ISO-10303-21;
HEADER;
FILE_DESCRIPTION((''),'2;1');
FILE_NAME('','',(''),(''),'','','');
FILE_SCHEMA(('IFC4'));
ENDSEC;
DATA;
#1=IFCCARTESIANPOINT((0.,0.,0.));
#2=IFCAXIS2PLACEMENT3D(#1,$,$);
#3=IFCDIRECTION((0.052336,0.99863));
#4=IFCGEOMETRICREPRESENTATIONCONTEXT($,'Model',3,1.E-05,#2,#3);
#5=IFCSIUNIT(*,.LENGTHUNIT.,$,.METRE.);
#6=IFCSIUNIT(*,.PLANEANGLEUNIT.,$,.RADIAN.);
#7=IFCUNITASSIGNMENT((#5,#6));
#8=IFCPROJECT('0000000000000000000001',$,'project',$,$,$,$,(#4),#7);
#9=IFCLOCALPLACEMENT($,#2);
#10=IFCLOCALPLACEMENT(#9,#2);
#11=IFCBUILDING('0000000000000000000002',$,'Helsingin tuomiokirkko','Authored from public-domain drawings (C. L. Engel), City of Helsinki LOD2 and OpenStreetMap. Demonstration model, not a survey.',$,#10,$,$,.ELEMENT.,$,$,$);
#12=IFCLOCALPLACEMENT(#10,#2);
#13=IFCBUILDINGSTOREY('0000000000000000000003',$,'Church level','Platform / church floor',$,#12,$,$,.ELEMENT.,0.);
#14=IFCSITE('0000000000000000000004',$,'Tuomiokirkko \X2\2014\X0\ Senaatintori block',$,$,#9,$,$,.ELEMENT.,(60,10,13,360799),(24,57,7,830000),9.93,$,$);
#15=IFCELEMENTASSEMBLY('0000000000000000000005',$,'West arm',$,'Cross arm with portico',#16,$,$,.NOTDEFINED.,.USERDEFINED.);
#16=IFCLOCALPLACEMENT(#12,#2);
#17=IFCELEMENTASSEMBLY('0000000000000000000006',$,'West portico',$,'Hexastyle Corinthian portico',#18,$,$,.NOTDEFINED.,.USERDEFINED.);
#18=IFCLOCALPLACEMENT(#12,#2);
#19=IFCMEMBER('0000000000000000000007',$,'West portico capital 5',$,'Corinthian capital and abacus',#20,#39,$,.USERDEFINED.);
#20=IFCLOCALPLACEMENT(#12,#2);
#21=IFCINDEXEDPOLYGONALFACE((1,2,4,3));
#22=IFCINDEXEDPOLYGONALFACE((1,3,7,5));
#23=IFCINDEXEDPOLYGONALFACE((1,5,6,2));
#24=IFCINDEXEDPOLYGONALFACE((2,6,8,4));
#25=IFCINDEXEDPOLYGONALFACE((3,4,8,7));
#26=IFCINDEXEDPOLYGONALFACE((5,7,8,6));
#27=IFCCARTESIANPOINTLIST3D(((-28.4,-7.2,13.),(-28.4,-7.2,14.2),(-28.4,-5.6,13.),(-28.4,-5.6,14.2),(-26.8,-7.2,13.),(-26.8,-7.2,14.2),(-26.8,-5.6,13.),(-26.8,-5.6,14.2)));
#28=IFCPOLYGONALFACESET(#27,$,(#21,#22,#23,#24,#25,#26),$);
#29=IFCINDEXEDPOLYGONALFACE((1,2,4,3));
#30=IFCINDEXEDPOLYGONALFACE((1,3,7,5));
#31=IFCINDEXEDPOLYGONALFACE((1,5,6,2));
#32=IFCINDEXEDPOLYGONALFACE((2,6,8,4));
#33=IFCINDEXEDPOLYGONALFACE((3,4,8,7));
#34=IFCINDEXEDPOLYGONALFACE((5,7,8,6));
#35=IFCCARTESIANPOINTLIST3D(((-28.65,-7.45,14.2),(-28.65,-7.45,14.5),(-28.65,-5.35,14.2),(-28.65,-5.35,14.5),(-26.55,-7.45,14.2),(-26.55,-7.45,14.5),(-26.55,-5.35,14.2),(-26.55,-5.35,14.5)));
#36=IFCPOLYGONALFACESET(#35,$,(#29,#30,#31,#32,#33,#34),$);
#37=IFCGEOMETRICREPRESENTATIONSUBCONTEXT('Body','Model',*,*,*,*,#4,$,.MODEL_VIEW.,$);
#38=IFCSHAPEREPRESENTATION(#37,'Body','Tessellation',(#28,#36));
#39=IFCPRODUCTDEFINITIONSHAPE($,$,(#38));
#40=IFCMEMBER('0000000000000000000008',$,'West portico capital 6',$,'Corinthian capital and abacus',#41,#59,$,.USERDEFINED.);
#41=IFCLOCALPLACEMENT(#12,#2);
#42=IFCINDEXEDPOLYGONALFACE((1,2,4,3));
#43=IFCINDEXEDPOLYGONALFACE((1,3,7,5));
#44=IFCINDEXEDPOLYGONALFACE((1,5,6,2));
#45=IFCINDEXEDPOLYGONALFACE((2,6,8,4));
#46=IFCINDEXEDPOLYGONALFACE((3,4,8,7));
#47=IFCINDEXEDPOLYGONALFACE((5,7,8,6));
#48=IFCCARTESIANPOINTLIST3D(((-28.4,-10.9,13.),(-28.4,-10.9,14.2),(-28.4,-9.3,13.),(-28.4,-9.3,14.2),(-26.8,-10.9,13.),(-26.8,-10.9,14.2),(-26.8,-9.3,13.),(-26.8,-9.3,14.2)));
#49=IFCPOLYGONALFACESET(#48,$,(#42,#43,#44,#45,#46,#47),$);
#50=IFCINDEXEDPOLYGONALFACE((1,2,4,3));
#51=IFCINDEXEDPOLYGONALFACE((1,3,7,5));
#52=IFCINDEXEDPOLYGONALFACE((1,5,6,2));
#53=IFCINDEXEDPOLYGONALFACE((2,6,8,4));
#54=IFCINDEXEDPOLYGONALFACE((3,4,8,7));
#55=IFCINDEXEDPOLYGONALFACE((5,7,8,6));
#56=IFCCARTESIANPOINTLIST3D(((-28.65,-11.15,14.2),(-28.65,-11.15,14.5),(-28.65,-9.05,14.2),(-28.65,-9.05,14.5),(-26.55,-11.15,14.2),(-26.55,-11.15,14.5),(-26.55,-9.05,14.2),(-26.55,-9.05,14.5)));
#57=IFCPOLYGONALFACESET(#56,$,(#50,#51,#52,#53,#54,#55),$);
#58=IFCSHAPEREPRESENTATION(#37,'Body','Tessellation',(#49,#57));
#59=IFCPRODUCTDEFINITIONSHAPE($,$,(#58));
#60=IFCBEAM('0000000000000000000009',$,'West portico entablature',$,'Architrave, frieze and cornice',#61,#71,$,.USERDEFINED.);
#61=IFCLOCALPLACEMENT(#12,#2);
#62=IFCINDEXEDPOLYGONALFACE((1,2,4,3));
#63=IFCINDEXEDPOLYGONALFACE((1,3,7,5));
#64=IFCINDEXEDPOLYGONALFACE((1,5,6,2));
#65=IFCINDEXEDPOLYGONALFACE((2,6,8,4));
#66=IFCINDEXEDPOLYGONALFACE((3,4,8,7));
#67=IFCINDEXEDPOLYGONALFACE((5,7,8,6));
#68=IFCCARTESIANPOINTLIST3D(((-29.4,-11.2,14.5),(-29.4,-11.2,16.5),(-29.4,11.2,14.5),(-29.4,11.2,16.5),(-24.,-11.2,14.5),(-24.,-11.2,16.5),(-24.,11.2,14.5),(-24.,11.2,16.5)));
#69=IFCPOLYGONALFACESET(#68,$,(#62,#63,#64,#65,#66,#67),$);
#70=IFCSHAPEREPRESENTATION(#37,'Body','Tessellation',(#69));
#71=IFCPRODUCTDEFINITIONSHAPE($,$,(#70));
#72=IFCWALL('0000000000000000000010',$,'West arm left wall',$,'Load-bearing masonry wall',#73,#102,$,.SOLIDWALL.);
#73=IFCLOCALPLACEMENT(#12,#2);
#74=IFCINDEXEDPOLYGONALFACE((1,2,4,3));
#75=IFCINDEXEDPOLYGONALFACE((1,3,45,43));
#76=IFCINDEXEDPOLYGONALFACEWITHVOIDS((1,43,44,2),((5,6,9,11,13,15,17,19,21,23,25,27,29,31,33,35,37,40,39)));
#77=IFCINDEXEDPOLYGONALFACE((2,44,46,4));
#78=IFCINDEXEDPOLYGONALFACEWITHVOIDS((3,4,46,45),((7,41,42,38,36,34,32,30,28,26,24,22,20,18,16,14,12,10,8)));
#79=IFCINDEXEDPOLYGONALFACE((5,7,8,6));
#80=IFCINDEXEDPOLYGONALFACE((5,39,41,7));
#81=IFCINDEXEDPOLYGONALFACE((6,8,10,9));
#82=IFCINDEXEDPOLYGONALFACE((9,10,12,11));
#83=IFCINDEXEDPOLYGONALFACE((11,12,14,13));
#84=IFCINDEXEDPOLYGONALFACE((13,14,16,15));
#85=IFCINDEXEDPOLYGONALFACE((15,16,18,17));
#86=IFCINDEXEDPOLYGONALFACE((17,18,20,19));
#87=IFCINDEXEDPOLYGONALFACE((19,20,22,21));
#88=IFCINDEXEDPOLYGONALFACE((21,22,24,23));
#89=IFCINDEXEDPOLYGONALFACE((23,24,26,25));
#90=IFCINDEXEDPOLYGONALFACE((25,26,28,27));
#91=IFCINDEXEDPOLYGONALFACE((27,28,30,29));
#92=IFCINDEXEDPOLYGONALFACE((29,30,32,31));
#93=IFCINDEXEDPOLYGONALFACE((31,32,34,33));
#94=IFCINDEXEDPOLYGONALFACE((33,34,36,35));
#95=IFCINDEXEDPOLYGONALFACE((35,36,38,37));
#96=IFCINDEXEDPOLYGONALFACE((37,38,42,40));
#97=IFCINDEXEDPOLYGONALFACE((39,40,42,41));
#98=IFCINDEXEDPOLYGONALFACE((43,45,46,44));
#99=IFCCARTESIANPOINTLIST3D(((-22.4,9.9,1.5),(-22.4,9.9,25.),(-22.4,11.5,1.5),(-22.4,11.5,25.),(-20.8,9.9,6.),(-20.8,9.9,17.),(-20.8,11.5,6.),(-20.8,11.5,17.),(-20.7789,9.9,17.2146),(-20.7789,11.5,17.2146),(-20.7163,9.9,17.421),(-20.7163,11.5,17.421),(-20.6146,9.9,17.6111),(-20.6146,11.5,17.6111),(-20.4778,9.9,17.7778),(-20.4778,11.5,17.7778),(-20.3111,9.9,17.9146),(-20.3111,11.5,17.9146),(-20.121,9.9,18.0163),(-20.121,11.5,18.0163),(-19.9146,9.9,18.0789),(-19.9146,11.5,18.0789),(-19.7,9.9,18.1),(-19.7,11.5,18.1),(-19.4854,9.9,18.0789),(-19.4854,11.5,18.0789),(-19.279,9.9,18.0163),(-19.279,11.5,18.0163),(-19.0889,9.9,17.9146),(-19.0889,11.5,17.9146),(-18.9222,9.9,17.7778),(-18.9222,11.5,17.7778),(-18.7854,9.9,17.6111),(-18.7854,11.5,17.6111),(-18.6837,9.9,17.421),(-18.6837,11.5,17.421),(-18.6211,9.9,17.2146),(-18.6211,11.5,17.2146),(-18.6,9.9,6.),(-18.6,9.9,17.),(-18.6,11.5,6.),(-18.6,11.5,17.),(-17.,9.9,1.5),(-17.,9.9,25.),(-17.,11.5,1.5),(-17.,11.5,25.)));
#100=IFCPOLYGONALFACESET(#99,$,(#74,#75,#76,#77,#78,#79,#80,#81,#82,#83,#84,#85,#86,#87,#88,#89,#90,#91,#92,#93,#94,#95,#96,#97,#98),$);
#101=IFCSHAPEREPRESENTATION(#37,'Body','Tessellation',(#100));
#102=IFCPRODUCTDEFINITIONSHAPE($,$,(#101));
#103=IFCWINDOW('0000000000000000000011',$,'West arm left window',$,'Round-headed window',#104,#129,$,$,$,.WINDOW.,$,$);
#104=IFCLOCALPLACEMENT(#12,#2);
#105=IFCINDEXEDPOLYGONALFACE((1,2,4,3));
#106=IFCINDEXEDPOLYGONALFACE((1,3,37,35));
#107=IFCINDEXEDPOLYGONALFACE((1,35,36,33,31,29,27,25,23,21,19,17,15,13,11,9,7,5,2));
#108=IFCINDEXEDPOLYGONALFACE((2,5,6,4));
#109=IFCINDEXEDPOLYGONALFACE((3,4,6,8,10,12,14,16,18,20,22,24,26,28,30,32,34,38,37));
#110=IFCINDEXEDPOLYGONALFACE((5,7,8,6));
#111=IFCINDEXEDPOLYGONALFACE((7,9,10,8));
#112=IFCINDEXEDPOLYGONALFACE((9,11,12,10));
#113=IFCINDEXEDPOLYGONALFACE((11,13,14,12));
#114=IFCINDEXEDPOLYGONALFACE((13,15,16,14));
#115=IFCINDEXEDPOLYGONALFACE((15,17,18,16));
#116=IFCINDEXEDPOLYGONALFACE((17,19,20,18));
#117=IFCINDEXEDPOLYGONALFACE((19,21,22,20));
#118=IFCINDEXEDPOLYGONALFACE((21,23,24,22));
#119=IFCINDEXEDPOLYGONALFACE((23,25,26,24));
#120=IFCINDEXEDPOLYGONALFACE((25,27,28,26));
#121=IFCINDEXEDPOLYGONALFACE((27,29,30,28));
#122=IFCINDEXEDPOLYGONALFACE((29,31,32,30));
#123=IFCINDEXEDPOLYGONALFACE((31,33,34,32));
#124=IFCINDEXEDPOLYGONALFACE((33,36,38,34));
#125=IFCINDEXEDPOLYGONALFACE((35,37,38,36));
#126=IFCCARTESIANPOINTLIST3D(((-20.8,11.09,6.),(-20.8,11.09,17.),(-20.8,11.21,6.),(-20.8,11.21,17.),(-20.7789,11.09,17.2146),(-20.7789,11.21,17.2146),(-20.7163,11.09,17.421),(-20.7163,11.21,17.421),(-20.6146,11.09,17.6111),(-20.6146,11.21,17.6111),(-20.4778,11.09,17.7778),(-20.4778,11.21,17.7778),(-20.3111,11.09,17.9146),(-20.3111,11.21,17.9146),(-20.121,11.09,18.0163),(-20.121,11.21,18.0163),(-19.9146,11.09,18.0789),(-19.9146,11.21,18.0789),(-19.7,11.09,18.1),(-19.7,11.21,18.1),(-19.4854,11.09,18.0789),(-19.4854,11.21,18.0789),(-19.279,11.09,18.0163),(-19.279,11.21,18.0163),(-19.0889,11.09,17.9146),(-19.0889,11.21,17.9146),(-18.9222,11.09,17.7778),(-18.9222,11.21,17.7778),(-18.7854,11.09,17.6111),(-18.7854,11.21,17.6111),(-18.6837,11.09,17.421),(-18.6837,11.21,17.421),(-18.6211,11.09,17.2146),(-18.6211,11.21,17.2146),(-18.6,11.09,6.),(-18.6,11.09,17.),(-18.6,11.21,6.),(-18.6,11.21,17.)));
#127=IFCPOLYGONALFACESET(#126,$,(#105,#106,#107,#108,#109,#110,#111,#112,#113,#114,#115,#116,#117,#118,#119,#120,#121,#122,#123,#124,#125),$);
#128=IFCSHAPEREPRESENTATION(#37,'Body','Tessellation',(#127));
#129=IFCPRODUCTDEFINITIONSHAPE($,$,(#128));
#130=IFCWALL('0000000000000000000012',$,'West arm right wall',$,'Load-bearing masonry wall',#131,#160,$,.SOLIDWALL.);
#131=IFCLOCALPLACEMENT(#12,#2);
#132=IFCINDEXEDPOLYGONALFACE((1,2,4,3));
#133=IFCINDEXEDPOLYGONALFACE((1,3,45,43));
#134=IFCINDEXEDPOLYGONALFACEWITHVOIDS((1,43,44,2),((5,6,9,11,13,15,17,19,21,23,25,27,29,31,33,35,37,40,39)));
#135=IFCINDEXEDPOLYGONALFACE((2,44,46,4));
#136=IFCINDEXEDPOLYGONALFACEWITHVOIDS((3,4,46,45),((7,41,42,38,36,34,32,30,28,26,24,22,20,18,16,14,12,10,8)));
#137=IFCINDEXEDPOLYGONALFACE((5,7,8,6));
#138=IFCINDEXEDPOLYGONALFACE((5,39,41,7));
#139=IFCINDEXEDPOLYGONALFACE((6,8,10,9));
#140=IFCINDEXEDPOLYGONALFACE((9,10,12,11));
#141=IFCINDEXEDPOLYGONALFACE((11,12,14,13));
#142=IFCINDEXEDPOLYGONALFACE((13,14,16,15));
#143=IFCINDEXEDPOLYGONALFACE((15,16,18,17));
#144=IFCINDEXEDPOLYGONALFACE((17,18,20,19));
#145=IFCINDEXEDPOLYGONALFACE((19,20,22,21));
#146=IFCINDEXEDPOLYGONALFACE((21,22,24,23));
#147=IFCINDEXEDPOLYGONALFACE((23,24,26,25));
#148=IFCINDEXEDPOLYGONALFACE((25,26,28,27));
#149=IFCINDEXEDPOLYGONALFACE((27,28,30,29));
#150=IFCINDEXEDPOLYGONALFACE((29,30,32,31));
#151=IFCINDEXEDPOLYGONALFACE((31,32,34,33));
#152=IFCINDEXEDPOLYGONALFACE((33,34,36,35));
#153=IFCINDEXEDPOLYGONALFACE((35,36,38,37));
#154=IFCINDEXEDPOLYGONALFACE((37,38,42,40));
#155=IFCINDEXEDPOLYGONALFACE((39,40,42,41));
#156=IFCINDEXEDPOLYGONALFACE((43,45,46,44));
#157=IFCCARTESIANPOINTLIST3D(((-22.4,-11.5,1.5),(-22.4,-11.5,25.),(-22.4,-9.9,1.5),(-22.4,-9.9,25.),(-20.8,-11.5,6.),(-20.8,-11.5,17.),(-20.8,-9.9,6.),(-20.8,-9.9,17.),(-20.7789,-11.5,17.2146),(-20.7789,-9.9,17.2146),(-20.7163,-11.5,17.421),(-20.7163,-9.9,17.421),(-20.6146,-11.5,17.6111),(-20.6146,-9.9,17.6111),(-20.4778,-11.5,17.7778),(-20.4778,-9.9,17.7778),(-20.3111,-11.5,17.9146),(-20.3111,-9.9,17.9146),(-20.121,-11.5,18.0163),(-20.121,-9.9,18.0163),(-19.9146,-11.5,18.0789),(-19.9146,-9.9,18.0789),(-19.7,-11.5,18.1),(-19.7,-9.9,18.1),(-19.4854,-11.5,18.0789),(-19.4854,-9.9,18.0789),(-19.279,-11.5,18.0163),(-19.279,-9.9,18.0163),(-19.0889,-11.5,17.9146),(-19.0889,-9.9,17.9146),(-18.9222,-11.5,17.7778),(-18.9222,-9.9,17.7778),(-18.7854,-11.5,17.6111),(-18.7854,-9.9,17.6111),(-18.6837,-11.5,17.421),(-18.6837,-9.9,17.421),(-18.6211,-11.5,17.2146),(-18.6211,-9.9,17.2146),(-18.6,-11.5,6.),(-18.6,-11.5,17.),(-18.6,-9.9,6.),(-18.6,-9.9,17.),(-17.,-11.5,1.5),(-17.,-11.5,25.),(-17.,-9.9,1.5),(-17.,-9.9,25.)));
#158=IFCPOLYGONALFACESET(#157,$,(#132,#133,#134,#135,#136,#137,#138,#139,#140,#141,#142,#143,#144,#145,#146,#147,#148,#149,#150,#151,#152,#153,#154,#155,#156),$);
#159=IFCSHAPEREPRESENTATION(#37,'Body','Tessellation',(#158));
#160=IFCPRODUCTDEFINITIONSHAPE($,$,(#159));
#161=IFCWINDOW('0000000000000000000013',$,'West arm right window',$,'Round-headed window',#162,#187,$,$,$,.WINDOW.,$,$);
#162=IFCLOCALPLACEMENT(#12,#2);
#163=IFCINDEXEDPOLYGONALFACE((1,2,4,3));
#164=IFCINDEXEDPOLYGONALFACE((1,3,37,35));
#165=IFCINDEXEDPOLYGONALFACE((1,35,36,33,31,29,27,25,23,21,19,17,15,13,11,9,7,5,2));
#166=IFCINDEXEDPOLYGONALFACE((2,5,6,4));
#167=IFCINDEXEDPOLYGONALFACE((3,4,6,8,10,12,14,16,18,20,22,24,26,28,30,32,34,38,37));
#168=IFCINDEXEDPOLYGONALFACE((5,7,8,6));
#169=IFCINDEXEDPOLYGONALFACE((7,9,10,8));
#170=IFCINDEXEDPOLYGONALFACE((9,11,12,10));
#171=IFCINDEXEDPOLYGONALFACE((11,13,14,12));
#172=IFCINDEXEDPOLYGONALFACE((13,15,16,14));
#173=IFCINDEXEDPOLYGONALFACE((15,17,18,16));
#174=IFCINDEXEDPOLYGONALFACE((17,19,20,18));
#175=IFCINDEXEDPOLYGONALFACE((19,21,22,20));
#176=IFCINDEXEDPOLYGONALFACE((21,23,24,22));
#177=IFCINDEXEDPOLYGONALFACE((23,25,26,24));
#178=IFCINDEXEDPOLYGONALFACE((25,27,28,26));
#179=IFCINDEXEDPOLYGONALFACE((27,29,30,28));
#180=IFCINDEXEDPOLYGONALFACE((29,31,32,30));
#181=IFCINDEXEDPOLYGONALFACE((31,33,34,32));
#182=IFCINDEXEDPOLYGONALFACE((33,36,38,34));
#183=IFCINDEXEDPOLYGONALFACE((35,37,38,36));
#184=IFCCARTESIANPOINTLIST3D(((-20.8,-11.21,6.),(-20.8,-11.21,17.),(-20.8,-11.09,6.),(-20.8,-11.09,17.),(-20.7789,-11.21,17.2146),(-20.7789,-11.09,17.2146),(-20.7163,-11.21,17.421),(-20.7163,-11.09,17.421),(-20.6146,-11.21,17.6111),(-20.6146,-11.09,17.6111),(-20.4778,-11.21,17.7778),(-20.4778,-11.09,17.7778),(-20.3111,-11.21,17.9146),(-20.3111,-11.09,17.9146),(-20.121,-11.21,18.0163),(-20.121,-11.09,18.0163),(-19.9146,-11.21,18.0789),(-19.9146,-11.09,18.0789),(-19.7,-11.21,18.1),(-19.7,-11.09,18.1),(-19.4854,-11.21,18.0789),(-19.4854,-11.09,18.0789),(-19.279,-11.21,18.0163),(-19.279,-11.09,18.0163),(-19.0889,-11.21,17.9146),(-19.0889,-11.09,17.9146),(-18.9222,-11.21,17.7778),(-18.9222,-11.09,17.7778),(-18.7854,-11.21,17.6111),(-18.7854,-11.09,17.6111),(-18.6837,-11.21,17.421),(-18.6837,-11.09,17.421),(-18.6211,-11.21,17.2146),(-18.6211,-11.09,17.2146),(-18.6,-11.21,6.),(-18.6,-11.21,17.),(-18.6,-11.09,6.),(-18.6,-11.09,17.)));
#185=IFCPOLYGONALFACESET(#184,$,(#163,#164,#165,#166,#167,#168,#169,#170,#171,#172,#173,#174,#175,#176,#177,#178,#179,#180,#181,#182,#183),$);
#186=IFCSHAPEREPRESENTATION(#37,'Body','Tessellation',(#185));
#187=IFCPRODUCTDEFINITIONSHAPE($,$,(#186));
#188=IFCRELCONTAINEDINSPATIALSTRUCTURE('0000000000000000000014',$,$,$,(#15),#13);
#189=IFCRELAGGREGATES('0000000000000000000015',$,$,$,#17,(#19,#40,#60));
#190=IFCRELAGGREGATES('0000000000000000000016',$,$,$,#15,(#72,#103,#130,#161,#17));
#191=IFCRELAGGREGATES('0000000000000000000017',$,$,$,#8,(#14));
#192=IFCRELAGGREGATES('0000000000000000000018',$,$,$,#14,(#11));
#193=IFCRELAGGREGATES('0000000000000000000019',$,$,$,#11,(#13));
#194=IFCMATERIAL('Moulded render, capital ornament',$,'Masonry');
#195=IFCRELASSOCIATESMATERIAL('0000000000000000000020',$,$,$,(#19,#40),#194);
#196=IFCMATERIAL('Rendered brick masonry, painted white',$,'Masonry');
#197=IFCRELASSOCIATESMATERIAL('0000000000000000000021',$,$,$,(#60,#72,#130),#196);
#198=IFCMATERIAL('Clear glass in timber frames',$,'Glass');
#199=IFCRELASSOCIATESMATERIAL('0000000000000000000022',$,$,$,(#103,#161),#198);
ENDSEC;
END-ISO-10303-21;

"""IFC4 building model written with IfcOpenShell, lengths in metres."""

from ifc_helpers import new_model, si_unit, direction, frame, frame_2d, origin, origin_2d_with_axis, place, context, subcontext, project, spatial, polyline, rectangle, outline, extrude, material, element, fill, aggregate, save


model = new_model("IFC4")

# Units and contexts
model_context = context("Model", 3, precision=1e-05, world=origin(), true_north=direction((0.052336, 0.99863)))
body_context = subcontext(model_context, "Body", "Model", "MODEL_VIEW")
ifc_project = project(units=[si_unit("LENGTHUNIT", "METRE"), si_unit("PLANEANGLEUNIT", "RADIAN")], contexts=[model_context])

# Site, building, storey
site_placement = place(None, origin())
site = spatial("IfcSite", under=ifc_project, at=site_placement, Name="Tuomiokirkko — Senaatintori block", CompositionType="ELEMENT", RefLatitude=(60, 10, 13, 360799), RefLongitude=(24, 57, 7, 830000), RefElevation=9.93)
building_placement = place(site_placement, origin())
building = spatial("IfcBuilding", under=site, at=building_placement, Name="Helsingin tuomiokirkko", Description="Authored from public-domain drawings (C. L. Engel), City of Helsinki LOD2 and OpenStreetMap. Demonstration model, not a survey.", CompositionType="ELEMENT")
storey_placement = place(building_placement, origin())
storey = spatial("IfcBuildingStorey", under=building, at=storey_placement, Name="Church level", Description="Platform / church floor", CompositionType="ELEMENT", Elevation=0.0)

# Element assemblies, members, beam, walls, openings, windows
assembly_1_placement = place(building_placement, origin())
assembly_1 = element("IfcElementAssembly", 1, at=assembly_1_placement, inside=storey, Name="West arm", ObjectType="Cross arm with portico", AssemblyPlace="NOTDEFINED", PredefinedType="USERDEFINED")
ifc_material_1 = material(Name="Rendered brick masonry, painted white", Category="Masonry")
assembly_2_placement = place(building_placement, origin())
assembly_2 = element("IfcElementAssembly", 2, at=assembly_2_placement, Name="West portico", ObjectType="Hexastyle Corinthian portico", AssemblyPlace="NOTDEFINED", PredefinedType="USERDEFINED")
ifc_material_2 = material(Name="Moulded render, capital ornament", Category="Masonry")
member_1_placement = place(building_placement, origin())
member_1 = element("IfcMember", 3, at=member_1_placement, material=ifc_material_2, Name="West portico capital 5", ObjectType="Corinthian capital and abacus", PredefinedType="USERDEFINED", context=body_context, shape_type="SweptSolid", body=[
    extrude(rectangle(XDim=1.6, YDim=1.6, at=origin_2d_with_axis()), frame((-27.6, -6.4, 13.0)), (0.0, 0.0, 1.0), 1.2),
    extrude(rectangle(XDim=2.1, YDim=2.1, at=origin_2d_with_axis()), frame((-27.6, -6.4, 14.2)), (0.0, 0.0, 1.0), 0.3),
])
member_2_placement = place(building_placement, origin())
member_2 = element("IfcMember", 4, at=member_2_placement, material=ifc_material_2, Name="West portico capital 6", ObjectType="Corinthian capital and abacus", PredefinedType="USERDEFINED", context=body_context, shape_type="SweptSolid", body=[
    extrude(rectangle(XDim=1.6, YDim=1.6, at=origin_2d_with_axis()), frame((-27.6, -10.1, 13.0)), (0.0, 0.0, 1.0), 1.2),
    extrude(rectangle(XDim=2.1, YDim=2.1, at=origin_2d_with_axis()), frame((-27.6, -10.1, 14.2)), (0.0, 0.0, 1.0), 0.3),
])
beam_1_placement = place(building_placement, origin())
beam_1 = element("IfcBeam", 5, at=beam_1_placement, material=ifc_material_1, Name="West portico entablature", ObjectType="Architrave, frieze and cornice", PredefinedType="USERDEFINED", context=body_context, shape_type="SweptSolid", body=[
    extrude(rectangle(XDim=5.4, YDim=22.4, at=origin_2d_with_axis()), frame((-26.7, 0.0, 14.5)), (0.0, 0.0, 1.0), 2.0),
])
ifc_material_3 = material(Name="Clear glass in timber frames", Category="Glass")
wall_1_placement = place(building_placement, origin())
wall_1 = element("IfcWall", 6, at=wall_1_placement, material=ifc_material_1, Name="West arm left wall", ObjectType="Load-bearing masonry wall", PredefinedType="SOLIDWALL", context=body_context, shape_type="SweptSolid", body=[
    extrude(rectangle(XDim=5.4, YDim=1.6, at=frame_2d((0.0, 0.0), x_axis=(-1.0, 0.0))), frame((-19.7, 10.7, 1.5)), (0.0, 0.0, 1.0), 23.5),
])
opening_1_placement = place(building_placement, origin())
opening_1 = element("IfcOpeningElement", 7, at=opening_1_placement, cuts=wall_1, PredefinedType="OPENING", context=body_context, shape_type="SweptSolid", body=[
    extrude(outline(polyline([(-1.1, 0.0), (1.1, 0.0), (1.1, 11.0), (1.0789, 11.2146), (1.0163, 11.421), (0.9146, 11.6111), (0.7778, 11.7778), (0.6111, 11.9146), (0.421, 12.0163), (0.2146, 12.0789), (0.0, 12.1), (-0.2146, 12.0789), (-0.421, 12.0163), (-0.6111, 11.9146), (-0.7778, 11.7778), (-0.9146, 11.6111), (-1.0163, 11.421), (-1.0789, 11.2146), (-1.1, 11.0), (-1.1, 0.0)])), frame((-19.7, 9.7, 6.0), z_axis=(0.0, 1.0, 0.0), x_axis=(-1.0, 0.0, 0.0)), (0.0, 0.0, 1.0), 2.0),
])
window_1_placement = place(building_placement, origin())
window_1 = element("IfcWindow", 8, at=window_1_placement, material=ifc_material_3, Name="West arm left window", ObjectType="Round-headed window", PredefinedType="WINDOW", context=body_context, shape_type="SweptSolid", body=[
    extrude(outline(polyline([(-1.1, 0.0), (1.1, 0.0), (1.1, 11.0), (1.0789, 11.2146), (1.0163, 11.421), (0.9146, 11.6111), (0.7778, 11.7778), (0.6111, 11.9146), (0.421, 12.0163), (0.2146, 12.0789), (0.0, 12.1), (-0.2146, 12.0789), (-0.421, 12.0163), (-0.6111, 11.9146), (-0.7778, 11.7778), (-0.9146, 11.6111), (-1.0163, 11.421), (-1.0789, 11.2146), (-1.1, 11.0), (-1.1, 0.0)])), frame((-19.7, 11.09, 6.0), z_axis=(0.0, 1.0, 0.0), x_axis=(-1.0, 0.0, 0.0)), (0.0, 0.0, 1.0), 0.12),
])
fill(opening_1, window_1)
wall_2_placement = place(building_placement, origin())
wall_2 = element("IfcWall", 9, at=wall_2_placement, material=ifc_material_1, Name="West arm right wall", ObjectType="Load-bearing masonry wall", PredefinedType="SOLIDWALL", context=body_context, shape_type="SweptSolid", body=[
    extrude(rectangle(XDim=5.4, YDim=1.6, at=frame_2d((0.0, 0.0), x_axis=(-1.0, 0.0))), frame((-19.7, -10.7, 1.5)), (0.0, 0.0, 1.0), 23.5),
])
opening_2_placement = place(building_placement, origin())
opening_2 = element("IfcOpeningElement", 10, at=opening_2_placement, cuts=wall_2, PredefinedType="OPENING", context=body_context, shape_type="SweptSolid", body=[
    extrude(outline(polyline([(-1.1, 0.0), (1.1, 0.0), (1.1, 11.0), (1.0789, 11.2146), (1.0163, 11.421), (0.9146, 11.6111), (0.7778, 11.7778), (0.6111, 11.9146), (0.421, 12.0163), (0.2146, 12.0789), (0.0, 12.1), (-0.2146, 12.0789), (-0.421, 12.0163), (-0.6111, 11.9146), (-0.7778, 11.7778), (-0.9146, 11.6111), (-1.0163, 11.421), (-1.0789, 11.2146), (-1.1, 11.0), (-1.1, 0.0)])), frame((-19.7, -11.7, 6.0), z_axis=(0.0, 1.0, 0.0), x_axis=(-1.0, 0.0, 0.0)), (0.0, 0.0, 1.0), 2.0),
])
window_2_placement = place(building_placement, origin())
window_2 = element("IfcWindow", 11, at=window_2_placement, material=ifc_material_3, Name="West arm right window", ObjectType="Round-headed window", PredefinedType="WINDOW", context=body_context, shape_type="SweptSolid", body=[
    extrude(outline(polyline([(-1.1, 0.0), (1.1, 0.0), (1.1, 11.0), (1.0789, 11.2146), (1.0163, 11.421), (0.9146, 11.6111), (0.7778, 11.7778), (0.6111, 11.9146), (0.421, 12.0163), (0.2146, 12.0789), (0.0, 12.1), (-0.2146, 12.0789), (-0.421, 12.0163), (-0.6111, 11.9146), (-0.7778, 11.7778), (-0.9146, 11.6111), (-1.0163, 11.421), (-1.0789, 11.2146), (-1.1, 11.0), (-1.1, 0.0)])), frame((-19.7, -11.21, 6.0), z_axis=(0.0, 1.0, 0.0), x_axis=(-1.0, 0.0, 0.0)), (0.0, 0.0, 1.0), 0.12),
])
fill(opening_2, window_2)

aggregate(assembly_2, [member_1, member_2, beam_1])

aggregate(assembly_1, [wall_1, window_1, wall_2, window_2, assembly_2])

save(model, "model.ifc")
